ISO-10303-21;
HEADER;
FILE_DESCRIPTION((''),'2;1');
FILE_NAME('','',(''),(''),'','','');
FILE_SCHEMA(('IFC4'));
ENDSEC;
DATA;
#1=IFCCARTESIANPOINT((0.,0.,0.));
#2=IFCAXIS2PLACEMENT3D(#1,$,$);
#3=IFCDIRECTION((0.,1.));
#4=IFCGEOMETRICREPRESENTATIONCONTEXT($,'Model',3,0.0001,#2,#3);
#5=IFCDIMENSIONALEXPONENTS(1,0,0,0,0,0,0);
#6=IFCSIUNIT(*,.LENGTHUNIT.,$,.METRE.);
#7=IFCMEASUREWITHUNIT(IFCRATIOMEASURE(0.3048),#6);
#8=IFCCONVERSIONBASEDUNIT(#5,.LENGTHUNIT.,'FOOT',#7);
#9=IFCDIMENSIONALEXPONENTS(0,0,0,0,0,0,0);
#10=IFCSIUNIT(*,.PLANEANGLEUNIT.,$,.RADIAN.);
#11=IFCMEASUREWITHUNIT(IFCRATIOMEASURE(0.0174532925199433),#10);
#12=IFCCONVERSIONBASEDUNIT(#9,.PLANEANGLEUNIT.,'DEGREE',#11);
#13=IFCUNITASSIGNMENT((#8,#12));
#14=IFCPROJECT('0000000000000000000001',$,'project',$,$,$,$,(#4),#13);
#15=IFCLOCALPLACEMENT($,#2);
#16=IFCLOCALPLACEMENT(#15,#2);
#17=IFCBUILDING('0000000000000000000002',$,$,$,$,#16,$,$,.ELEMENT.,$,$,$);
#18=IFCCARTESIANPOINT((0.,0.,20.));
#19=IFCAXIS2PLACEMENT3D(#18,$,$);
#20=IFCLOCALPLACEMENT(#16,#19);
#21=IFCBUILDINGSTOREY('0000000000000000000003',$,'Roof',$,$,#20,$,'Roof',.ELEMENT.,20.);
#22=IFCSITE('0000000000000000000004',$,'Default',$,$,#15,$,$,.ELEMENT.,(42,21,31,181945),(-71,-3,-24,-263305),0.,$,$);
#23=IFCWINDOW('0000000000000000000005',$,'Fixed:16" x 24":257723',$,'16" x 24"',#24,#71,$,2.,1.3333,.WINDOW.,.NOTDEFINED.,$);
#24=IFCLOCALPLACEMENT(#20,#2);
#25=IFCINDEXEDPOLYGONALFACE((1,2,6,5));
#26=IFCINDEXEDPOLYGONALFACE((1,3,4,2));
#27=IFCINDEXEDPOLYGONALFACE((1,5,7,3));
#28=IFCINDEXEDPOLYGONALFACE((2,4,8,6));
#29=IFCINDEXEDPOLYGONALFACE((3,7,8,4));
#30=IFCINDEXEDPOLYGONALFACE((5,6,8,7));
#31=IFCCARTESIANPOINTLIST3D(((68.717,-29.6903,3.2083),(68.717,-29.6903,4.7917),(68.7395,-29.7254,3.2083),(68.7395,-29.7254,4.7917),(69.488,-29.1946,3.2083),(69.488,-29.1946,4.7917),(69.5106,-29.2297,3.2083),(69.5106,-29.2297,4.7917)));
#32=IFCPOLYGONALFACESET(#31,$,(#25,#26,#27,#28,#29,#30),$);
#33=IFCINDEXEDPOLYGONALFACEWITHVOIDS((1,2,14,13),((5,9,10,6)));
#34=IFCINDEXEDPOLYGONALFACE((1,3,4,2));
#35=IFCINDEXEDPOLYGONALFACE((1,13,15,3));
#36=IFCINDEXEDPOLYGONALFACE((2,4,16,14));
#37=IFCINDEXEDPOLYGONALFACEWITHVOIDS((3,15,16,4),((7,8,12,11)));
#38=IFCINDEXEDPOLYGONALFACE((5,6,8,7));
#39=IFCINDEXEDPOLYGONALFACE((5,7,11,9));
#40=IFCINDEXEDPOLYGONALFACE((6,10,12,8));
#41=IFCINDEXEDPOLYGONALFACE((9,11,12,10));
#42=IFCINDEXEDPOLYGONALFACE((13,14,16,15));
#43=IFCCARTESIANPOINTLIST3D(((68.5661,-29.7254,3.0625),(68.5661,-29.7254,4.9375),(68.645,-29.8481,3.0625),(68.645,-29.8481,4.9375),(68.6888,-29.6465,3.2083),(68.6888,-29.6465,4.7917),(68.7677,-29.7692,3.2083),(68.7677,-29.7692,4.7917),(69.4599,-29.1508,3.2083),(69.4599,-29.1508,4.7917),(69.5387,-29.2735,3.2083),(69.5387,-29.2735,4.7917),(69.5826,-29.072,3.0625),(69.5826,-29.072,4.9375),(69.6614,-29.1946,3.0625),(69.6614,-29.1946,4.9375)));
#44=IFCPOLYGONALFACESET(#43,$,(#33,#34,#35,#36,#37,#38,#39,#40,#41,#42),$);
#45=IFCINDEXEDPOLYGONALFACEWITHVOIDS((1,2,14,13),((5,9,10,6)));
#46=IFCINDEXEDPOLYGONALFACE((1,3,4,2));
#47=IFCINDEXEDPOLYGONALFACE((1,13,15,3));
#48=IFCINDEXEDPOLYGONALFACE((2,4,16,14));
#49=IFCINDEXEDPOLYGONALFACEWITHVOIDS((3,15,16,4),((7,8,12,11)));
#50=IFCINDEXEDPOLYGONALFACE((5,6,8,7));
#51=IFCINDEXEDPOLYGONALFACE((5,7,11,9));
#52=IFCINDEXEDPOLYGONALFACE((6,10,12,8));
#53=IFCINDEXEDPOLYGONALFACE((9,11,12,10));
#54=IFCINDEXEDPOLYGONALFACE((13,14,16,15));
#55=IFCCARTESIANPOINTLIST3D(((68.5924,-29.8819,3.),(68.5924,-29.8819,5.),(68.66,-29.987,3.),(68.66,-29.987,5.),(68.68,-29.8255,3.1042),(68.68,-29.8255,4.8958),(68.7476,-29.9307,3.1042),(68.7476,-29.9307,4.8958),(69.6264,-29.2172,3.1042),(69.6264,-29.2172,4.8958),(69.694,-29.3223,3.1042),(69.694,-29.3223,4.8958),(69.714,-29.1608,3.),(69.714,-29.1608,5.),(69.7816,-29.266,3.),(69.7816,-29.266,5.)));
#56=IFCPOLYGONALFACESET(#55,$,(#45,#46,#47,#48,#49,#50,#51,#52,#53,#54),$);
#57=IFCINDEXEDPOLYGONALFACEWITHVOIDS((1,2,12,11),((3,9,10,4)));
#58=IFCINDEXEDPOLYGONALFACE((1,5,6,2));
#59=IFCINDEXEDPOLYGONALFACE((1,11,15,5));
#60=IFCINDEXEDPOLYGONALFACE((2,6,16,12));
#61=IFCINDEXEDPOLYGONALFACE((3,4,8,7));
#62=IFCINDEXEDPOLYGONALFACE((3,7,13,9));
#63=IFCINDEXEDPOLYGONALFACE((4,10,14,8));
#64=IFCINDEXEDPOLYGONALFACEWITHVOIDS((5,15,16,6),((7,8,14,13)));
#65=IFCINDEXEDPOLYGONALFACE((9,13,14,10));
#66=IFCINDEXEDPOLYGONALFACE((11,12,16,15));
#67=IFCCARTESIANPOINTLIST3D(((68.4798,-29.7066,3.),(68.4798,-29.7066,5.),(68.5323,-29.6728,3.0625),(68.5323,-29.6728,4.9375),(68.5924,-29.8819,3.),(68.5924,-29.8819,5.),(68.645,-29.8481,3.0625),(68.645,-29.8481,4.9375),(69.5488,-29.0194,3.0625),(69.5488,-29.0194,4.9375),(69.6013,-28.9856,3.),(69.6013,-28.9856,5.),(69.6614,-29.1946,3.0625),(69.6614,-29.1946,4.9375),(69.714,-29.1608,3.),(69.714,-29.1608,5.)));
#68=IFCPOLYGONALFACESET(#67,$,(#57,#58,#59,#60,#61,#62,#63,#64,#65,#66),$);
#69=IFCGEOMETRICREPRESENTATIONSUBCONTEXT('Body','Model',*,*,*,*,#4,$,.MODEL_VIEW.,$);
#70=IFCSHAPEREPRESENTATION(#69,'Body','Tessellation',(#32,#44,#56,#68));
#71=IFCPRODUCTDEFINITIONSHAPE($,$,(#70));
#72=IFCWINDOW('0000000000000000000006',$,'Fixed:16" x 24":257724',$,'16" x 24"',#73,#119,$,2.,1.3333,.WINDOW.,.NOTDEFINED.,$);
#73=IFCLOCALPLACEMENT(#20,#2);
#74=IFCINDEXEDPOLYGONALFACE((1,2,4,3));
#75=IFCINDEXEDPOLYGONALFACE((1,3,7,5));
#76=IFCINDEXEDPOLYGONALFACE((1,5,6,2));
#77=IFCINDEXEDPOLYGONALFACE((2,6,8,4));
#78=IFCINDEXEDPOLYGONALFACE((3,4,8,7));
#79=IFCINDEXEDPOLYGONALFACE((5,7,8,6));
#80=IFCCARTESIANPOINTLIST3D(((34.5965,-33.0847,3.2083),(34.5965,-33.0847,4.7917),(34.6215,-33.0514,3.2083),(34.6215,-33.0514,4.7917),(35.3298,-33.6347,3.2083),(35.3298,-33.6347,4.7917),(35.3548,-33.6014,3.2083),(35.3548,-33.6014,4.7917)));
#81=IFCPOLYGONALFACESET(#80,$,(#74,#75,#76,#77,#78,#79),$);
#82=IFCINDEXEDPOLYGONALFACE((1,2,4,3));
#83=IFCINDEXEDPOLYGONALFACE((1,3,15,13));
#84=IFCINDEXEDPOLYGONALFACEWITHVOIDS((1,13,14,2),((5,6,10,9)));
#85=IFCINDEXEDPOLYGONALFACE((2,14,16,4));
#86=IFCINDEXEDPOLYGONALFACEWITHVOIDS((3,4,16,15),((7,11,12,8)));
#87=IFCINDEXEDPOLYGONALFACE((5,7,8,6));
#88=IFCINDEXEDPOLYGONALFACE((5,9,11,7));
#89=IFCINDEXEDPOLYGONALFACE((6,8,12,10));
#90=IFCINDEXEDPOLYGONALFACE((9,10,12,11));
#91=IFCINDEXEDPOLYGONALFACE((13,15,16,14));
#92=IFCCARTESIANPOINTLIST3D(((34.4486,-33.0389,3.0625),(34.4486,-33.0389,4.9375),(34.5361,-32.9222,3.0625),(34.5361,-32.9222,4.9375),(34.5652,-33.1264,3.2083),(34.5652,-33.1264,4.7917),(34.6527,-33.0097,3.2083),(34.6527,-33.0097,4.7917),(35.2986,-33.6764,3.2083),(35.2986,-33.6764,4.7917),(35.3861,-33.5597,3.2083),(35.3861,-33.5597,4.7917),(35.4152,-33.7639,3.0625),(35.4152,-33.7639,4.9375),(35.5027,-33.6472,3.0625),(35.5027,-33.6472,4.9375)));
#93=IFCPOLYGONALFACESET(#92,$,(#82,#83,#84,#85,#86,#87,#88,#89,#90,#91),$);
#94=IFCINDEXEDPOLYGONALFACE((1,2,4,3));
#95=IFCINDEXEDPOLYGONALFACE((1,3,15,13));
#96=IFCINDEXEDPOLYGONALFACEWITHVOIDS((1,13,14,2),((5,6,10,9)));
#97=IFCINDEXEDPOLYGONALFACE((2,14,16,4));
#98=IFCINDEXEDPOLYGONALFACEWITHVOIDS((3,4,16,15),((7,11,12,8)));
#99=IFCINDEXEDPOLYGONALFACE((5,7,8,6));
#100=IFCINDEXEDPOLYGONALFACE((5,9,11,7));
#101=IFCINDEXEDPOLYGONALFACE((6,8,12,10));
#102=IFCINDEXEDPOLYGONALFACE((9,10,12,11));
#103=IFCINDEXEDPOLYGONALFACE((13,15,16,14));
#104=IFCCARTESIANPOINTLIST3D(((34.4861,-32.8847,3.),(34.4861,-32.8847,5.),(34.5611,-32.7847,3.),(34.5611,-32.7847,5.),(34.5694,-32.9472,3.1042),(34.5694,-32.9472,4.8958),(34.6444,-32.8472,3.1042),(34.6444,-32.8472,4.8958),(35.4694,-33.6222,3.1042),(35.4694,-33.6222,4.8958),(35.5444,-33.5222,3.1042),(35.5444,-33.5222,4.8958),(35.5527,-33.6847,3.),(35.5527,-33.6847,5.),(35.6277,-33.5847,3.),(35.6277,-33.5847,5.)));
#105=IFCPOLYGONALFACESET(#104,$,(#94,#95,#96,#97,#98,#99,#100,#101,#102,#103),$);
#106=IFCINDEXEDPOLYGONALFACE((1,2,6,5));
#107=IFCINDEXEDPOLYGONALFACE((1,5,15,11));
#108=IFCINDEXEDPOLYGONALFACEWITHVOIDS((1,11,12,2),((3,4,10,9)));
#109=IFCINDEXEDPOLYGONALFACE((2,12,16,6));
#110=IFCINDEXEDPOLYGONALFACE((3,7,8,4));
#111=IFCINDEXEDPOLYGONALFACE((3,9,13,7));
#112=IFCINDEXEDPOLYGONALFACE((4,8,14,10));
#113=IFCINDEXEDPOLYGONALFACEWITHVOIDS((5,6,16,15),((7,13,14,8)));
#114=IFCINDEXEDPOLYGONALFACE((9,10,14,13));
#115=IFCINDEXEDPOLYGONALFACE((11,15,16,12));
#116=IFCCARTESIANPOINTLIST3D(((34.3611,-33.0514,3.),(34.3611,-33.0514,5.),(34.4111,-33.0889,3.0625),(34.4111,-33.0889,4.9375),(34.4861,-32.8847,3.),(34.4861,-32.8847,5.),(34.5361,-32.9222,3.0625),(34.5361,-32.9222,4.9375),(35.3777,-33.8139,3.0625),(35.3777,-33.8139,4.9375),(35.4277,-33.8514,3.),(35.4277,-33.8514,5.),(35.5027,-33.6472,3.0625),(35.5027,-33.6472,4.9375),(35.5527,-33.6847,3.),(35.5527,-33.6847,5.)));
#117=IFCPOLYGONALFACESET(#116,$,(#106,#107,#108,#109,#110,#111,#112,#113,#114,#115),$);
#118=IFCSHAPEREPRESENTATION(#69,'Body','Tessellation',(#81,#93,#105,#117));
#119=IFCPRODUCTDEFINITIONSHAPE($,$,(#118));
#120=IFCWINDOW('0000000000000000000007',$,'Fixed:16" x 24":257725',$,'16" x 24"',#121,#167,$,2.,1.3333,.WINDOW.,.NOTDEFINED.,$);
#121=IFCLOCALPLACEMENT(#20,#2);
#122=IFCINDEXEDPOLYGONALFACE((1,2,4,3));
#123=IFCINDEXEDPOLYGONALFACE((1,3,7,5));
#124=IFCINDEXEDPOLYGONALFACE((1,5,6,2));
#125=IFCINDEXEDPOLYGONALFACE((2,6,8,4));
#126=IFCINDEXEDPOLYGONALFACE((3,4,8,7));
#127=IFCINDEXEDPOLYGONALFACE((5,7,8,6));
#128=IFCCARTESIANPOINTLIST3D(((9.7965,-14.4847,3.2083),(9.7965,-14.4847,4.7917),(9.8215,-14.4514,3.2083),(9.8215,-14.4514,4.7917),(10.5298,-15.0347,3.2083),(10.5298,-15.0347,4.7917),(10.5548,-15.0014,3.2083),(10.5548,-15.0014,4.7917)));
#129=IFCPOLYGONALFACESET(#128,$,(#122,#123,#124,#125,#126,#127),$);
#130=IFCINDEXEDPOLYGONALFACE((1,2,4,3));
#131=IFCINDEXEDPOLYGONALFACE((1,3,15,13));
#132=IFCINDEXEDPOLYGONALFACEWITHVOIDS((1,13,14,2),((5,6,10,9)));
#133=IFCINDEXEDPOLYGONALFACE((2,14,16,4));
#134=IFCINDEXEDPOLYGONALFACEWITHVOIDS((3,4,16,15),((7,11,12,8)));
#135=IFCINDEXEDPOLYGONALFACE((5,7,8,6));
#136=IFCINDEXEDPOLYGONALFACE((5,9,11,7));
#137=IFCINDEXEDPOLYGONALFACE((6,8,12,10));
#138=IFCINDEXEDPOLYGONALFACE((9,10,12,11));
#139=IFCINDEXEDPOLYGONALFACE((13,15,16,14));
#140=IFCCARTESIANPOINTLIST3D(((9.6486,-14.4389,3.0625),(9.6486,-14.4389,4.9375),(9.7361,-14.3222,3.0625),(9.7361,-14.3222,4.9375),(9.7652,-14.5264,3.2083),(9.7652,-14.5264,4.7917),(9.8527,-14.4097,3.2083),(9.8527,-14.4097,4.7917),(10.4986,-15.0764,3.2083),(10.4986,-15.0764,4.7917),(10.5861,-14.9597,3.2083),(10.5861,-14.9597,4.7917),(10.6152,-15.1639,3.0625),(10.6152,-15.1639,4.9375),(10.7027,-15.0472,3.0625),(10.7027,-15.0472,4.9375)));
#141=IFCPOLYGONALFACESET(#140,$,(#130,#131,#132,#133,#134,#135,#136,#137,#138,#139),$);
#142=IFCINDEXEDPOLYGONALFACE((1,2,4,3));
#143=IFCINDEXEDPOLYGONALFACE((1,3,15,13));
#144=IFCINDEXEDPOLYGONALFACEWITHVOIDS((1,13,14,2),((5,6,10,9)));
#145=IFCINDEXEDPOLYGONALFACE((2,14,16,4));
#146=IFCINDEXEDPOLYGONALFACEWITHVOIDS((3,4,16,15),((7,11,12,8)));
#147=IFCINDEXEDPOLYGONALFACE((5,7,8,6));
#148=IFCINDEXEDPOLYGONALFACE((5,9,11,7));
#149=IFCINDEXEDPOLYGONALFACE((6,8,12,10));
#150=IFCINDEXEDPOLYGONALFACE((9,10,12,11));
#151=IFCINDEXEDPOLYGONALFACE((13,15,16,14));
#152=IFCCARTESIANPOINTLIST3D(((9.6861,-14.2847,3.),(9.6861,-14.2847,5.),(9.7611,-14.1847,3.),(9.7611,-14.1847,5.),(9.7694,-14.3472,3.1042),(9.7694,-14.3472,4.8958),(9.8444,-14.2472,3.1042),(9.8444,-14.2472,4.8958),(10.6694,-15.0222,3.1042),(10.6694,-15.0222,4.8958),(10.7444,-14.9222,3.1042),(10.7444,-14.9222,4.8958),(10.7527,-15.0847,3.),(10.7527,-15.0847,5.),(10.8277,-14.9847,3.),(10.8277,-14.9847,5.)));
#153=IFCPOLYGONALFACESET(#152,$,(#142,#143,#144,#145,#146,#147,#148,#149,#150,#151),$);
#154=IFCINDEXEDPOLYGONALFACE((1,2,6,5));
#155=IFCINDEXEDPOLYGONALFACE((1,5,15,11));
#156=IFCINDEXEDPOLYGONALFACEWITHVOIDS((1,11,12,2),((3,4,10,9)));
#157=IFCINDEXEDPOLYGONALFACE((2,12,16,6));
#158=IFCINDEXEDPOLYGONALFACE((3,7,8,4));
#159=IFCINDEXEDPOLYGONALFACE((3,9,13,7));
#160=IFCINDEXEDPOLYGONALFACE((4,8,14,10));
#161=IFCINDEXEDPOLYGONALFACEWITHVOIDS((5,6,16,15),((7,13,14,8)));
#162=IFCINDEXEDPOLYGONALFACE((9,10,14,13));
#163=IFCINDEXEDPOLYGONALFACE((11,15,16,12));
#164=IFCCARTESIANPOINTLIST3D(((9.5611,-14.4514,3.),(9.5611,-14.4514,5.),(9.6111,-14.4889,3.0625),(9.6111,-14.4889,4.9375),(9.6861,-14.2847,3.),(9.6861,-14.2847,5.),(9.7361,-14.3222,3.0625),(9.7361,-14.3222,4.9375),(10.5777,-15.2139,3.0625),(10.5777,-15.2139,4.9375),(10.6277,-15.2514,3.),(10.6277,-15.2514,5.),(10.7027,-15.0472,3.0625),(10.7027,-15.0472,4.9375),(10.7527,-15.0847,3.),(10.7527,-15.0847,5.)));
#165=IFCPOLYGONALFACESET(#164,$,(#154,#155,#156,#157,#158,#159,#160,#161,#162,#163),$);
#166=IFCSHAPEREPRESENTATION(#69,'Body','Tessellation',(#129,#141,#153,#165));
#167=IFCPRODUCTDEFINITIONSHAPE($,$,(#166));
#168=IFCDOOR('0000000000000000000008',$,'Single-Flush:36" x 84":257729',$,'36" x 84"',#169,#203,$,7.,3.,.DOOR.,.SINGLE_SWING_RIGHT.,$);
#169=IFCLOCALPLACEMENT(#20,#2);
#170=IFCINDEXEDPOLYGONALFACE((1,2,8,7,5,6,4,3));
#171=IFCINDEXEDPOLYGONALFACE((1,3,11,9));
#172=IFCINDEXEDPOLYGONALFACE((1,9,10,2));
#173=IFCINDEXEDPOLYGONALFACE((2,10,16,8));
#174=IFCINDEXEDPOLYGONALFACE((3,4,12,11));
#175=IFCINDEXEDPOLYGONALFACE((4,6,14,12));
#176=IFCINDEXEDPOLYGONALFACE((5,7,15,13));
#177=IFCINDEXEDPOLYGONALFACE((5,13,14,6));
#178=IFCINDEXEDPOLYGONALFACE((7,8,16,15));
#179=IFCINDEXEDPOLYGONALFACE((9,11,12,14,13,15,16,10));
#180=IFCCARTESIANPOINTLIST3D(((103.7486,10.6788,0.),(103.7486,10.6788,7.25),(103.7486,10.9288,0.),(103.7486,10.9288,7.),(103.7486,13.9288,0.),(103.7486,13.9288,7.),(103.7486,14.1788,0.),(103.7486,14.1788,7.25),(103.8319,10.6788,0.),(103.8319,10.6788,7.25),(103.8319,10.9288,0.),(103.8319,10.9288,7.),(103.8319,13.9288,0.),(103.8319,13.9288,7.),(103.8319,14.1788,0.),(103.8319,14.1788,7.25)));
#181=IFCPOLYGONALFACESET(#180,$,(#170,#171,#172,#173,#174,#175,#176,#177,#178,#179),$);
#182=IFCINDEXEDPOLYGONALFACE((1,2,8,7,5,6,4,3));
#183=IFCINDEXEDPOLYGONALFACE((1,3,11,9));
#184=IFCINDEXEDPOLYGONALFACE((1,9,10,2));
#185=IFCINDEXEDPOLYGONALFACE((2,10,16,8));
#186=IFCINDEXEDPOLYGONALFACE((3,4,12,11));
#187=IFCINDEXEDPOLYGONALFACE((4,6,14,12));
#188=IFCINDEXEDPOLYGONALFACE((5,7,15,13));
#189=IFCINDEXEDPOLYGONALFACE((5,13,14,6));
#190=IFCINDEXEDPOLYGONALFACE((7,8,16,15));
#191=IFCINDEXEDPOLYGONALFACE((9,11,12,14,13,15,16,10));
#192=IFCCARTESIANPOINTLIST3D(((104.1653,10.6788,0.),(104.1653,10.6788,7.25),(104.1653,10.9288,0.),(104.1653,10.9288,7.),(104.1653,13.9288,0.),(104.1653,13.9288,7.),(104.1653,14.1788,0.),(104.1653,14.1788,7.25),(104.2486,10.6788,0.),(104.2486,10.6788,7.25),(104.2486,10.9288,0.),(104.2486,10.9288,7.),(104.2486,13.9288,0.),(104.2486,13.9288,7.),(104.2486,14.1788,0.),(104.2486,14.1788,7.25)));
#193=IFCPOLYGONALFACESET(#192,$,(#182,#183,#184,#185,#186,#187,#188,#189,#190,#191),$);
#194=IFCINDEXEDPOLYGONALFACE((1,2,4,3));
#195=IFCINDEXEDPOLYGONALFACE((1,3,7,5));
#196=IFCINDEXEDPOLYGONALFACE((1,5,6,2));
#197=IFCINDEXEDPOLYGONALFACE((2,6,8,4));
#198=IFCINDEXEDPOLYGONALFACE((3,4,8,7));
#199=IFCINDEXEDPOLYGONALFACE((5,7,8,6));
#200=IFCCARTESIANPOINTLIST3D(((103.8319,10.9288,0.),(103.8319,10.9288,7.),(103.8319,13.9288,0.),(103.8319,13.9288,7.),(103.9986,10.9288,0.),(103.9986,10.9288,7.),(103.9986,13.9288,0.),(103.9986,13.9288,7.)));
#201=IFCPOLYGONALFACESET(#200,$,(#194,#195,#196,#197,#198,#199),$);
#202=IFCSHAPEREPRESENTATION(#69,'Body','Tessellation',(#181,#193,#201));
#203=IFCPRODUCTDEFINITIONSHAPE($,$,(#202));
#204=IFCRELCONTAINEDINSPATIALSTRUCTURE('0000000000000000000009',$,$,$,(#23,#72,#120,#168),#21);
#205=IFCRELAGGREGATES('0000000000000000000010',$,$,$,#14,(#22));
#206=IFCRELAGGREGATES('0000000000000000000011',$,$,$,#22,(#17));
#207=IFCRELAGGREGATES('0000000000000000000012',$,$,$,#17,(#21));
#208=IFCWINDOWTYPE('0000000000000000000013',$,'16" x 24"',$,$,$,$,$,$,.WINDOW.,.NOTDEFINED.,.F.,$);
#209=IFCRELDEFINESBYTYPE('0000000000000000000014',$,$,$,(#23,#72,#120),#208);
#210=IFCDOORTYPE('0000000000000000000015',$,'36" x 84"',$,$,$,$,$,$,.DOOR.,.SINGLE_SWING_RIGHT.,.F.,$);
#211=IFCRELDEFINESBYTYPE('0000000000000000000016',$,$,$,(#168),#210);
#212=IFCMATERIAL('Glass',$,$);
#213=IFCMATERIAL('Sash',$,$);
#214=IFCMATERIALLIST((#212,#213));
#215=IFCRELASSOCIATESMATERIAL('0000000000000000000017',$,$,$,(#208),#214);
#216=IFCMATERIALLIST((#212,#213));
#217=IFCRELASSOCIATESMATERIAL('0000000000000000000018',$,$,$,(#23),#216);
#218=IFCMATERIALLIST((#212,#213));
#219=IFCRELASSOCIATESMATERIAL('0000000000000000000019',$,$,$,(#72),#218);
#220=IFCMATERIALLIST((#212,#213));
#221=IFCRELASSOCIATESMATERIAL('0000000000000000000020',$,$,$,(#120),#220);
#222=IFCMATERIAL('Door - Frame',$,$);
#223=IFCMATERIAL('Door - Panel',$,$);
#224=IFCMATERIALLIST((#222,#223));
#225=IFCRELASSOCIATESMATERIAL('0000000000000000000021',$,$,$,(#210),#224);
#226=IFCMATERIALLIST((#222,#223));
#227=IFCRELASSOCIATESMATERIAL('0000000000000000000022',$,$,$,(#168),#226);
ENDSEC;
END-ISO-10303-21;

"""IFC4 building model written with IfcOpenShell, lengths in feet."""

from ifc_helpers import new_model, entity, si_unit, converted_unit, direction, frame, frame_2d, origin, origin_2d_with_axis, place, context, subcontext, project, spatial, polyline, rectangle, outline, extrude, source, transform, mapped, material, material_list, type_object, type_shapes, element, save


model = new_model("IFC4")

# Units and contexts
model_context = context("Model", 3, precision=0.0001, world=origin(), true_north=direction((0.0, 1.0)))
body_context = subcontext(model_context, "Body", "Model", "MODEL_VIEW")
ifc_project = project(units=[converted_unit("LENGTHUNIT", "FOOT", entity("IfcRatioMeasure", 0.3048), si_unit("LENGTHUNIT", "METRE"), dimensions=[1, 0, 0, 0, 0, 0, 0]), converted_unit("PLANEANGLEUNIT", "DEGREE", entity("IfcRatioMeasure", 0.0174532925199433), si_unit("PLANEANGLEUNIT", "RADIAN"), dimensions=[0, 0, 0, 0, 0, 0, 0])], contexts=[model_context])

# Site, building, storey
site_placement = place(None, origin())
site = spatial("IfcSite", under=ifc_project, at=site_placement, Name="Default", CompositionType="ELEMENT", RefLatitude=(42, 21, 31, 181945), RefLongitude=(-71, -3, -24, -263305), RefElevation=0.0)
building_placement = place(site_placement, origin())
building = spatial("IfcBuilding", under=site, at=building_placement, CompositionType="ELEMENT")
storey_placement = place(building_placement, frame((0.0, 0.0, 20.0)))
storey = spatial("IfcBuildingStorey", under=building, at=storey_placement, Name="Roof", LongName="Roof", CompositionType="ELEMENT", Elevation=20.0)

# Windows
ifc_material_1 = material(Name="Glass")
ifc_material_2 = material(Name="Sash")
ifc_material_list_1 = material_list([ifc_material_1, ifc_material_2])
window_type = type_object("IfcWindowType", Name="16\" x 24\"", ParameterTakesPrecedence=False, PartitioningType="NOTDEFINED", PredefinedType="WINDOW", material=ifc_material_list_1)
shared_shape_1 = source(origin(), body_context, "Body", "SweptSolid", [
    extrude(rectangle(XDim=0.0417, YDim=0.9167, at=origin_2d_with_axis()), frame((0.6667, 0.1979, 0.2083), z_axis=(0.0, 0.0, 1.0), x_axis=(0.0, 1.0, 0.0)), (0.0, 0.0, 1.0), 1.5833),
    extrude(outline(polyline([(-0.6042, -0.9375), (0.6042, -0.9375), (0.6042, 0.9375), (-0.6042, 0.9375), (-0.6042, -0.9375)]), holes=[polyline([(-0.4583, -0.7917), (-0.4583, 0.7917), (0.4583, 0.7917), (0.4583, -0.7917), (-0.4583, -0.7917)])]), frame((0.6667, 0.125, 1.0), z_axis=(0.0, 1.0, 0.0), x_axis=(1.0, 0.0, 0.0)), (0.0, 0.0, 1.0), 0.1458),
    extrude(outline(polyline([(-0.6667, -1.0), (0.6667, -1.0), (0.6667, 1.0), (-0.6667, 1.0), (-0.6667, -1.0)]), holes=[polyline([(-0.5625, -0.8958), (-0.5625, 0.8958), (0.5625, 0.8958), (0.5625, -0.8958), (-0.5625, -0.8958)])]), frame((0.6667, 0.0, 1.0), z_axis=(0.0, 1.0, 0.0), x_axis=(1.0, 0.0, 0.0)), (0.0, 0.0, 1.0), 0.125),
    extrude(outline(polyline([(-1.0, -0.6667), (1.0, -0.6667), (1.0, 0.6667), (-1.0, 0.6667), (-1.0, -0.6667)]), holes=[polyline([(-0.9375, -0.6042), (-0.9375, 0.6042), (0.9375, 0.6042), (0.9375, -0.6042), (-0.9375, -0.6042)])]), frame((0.6667, 0.125, 1.0), z_axis=(0.0, 1.0, 0.0), x_axis=(0.0, 0.0, -1.0)), (0.0, 0.0, 1.0), 0.2083),
])
type_shapes(window_type, [shared_shape_1])
placement_1 = place(building_placement, frame((0.0, 0.0, 10.0)))
placement_2 = place(placement_1, frame((103.9574, -7.0977, 0.0), z_axis=(0.0, 0.0, 1.0), x_axis=(-0.841178, -0.540758, 0.0)))
ifc_material_list_2 = material_list([ifc_material_1, ifc_material_2])
placement_3 = place(placement_2, frame((42.069, 0.1667, 13.0)))
window_1_placement = place(placement_3, frame((0.0, 0.0, 0.0), z_axis=(0.0, 0.0, 1.0), x_axis=(-1.0, 0.0, 0.0)))
element("IfcWindow", 1, at=window_1_placement, inside=storey, type_object=window_type, material=ifc_material_list_2, Name="Fixed:16\" x 24\":257723", ObjectType="16\" x 24\"", OverallHeight=2.0, OverallWidth=1.3333, PartitioningType="NOTDEFINED", PredefinedType="WINDOW", context=body_context, shape_type="MappedRepresentation", body=[
    mapped(shared_shape_1, transform((0.0, 0.0, 0.0), scale=1.0)),
])
ifc_material_list_3 = material_list([ifc_material_1, ifc_material_2])
placement_4 = place(placement_1, frame((47.9059, -43.0017, 0.0), z_axis=(0.0, 0.0, 1.0), x_axis=(-0.8, 0.6, 0.0)))
placement_5 = place(placement_4, frame((15.4728, -0.1667, 13.0)))
window_2_placement = place(placement_5, origin())
element("IfcWindow", 2, at=window_2_placement, inside=storey, type_object=window_type, material=ifc_material_list_3, Name="Fixed:16\" x 24\":257724", ObjectType="16\" x 24\"", OverallHeight=2.0, OverallWidth=1.3333, PartitioningType="NOTDEFINED", PredefinedType="WINDOW", context=body_context, shape_type="MappedRepresentation", body=[
    mapped(shared_shape_1, transform((0.0, 0.0, 0.0), scale=1.0)),
])
ifc_material_list_4 = material_list([ifc_material_1, ifc_material_2])
placement_6 = place(placement_4, frame((46.4728, -0.1667, 13.0)))
window_3_placement = place(placement_6, origin())
element("IfcWindow", 3, at=window_3_placement, inside=storey, type_object=window_type, material=ifc_material_list_4, Name="Fixed:16\" x 24\":257725", ObjectType="16\" x 24\"", OverallHeight=2.0, OverallWidth=1.3333, PartitioningType="NOTDEFINED", PredefinedType="WINDOW", context=body_context, shape_type="MappedRepresentation", body=[
    mapped(shared_shape_1, transform((0.0, 0.0, 0.0), scale=1.0)),
])

# Door
ifc_material_3 = material(Name="Door - Frame")
ifc_material_4 = material(Name="Door - Panel")
ifc_material_list_5 = material_list([ifc_material_3, ifc_material_4])
door_type = type_object("IfcDoorType", Name="36\" x 84\"", OperationType="SINGLE_SWING_RIGHT", ParameterTakesPrecedence=False, PredefinedType="DOOR", material=ifc_material_list_5)
shared_shape_2 = source(origin(), body_context, "Body", "SweptSolid", [
    extrude(outline(polyline([(-1.75, -3.6875), (1.75, -3.6875), (1.75, 3.5625), (1.5, 3.5625), (1.5, -3.4375), (-1.5, -3.4375), (-1.5, 3.5625), (-1.75, 3.5625), (-1.75, -3.6875)])), frame((1.5, 0.3333, 3.5625), z_axis=(0.0, 1.0, 0.0), x_axis=(1.0, 0.0, 0.0)), (0.0, 0.0, 1.0), 0.0833),
    extrude(outline(polyline([(-3.6875, -1.75), (3.5625, -1.75), (3.5625, -1.5), (-3.4375, -1.5), (-3.4375, 1.5), (3.5625, 1.5), (3.5625, 1.75), (-3.6875, 1.75), (-3.6875, -1.75)])), frame((1.5, -0.0833, 3.5625), z_axis=(0.0, 1.0, 0.0), x_axis=(0.0, 0.0, -1.0)), (0.0, 0.0, 1.0), 0.0833),
    extrude(rectangle(XDim=0.1667, YDim=3.0, at=frame_2d((0.0, 0.0), x_axis=(1.0, 0.0))), frame((1.5, 0.25, 0.0), z_axis=(0.0, 0.0, 1.0), x_axis=(0.0, 1.0, 0.0)), (0.0, 0.0, 1.0), 7.0),
])
type_shapes(door_type, [shared_shape_2])
ifc_material_list_6 = material_list([ifc_material_3, ifc_material_4])
placement_7 = place(placement_1, frame((103.9986, -6.9045, 0.0), z_axis=(0.0, 0.0, 1.0), x_axis=(0.0, 1.0, 0.0)))
placement_8 = place(placement_7, frame((17.8333, -0.1667, 10.0)))
door_1_placement = place(placement_8, origin())
element("IfcDoor", 4, at=door_1_placement, inside=storey, type_object=door_type, material=ifc_material_list_6, Name="Single-Flush:36\" x 84\":257729", ObjectType="36\" x 84\"", OperationType="SINGLE_SWING_RIGHT", OverallHeight=7.0, OverallWidth=3.0, PredefinedType="DOOR", context=body_context, shape_type="MappedRepresentation", body=[
    mapped(shared_shape_2, transform((0.0, 0.0, 0.0), scale=1.0)),
])

save(model, "model.ifc")
